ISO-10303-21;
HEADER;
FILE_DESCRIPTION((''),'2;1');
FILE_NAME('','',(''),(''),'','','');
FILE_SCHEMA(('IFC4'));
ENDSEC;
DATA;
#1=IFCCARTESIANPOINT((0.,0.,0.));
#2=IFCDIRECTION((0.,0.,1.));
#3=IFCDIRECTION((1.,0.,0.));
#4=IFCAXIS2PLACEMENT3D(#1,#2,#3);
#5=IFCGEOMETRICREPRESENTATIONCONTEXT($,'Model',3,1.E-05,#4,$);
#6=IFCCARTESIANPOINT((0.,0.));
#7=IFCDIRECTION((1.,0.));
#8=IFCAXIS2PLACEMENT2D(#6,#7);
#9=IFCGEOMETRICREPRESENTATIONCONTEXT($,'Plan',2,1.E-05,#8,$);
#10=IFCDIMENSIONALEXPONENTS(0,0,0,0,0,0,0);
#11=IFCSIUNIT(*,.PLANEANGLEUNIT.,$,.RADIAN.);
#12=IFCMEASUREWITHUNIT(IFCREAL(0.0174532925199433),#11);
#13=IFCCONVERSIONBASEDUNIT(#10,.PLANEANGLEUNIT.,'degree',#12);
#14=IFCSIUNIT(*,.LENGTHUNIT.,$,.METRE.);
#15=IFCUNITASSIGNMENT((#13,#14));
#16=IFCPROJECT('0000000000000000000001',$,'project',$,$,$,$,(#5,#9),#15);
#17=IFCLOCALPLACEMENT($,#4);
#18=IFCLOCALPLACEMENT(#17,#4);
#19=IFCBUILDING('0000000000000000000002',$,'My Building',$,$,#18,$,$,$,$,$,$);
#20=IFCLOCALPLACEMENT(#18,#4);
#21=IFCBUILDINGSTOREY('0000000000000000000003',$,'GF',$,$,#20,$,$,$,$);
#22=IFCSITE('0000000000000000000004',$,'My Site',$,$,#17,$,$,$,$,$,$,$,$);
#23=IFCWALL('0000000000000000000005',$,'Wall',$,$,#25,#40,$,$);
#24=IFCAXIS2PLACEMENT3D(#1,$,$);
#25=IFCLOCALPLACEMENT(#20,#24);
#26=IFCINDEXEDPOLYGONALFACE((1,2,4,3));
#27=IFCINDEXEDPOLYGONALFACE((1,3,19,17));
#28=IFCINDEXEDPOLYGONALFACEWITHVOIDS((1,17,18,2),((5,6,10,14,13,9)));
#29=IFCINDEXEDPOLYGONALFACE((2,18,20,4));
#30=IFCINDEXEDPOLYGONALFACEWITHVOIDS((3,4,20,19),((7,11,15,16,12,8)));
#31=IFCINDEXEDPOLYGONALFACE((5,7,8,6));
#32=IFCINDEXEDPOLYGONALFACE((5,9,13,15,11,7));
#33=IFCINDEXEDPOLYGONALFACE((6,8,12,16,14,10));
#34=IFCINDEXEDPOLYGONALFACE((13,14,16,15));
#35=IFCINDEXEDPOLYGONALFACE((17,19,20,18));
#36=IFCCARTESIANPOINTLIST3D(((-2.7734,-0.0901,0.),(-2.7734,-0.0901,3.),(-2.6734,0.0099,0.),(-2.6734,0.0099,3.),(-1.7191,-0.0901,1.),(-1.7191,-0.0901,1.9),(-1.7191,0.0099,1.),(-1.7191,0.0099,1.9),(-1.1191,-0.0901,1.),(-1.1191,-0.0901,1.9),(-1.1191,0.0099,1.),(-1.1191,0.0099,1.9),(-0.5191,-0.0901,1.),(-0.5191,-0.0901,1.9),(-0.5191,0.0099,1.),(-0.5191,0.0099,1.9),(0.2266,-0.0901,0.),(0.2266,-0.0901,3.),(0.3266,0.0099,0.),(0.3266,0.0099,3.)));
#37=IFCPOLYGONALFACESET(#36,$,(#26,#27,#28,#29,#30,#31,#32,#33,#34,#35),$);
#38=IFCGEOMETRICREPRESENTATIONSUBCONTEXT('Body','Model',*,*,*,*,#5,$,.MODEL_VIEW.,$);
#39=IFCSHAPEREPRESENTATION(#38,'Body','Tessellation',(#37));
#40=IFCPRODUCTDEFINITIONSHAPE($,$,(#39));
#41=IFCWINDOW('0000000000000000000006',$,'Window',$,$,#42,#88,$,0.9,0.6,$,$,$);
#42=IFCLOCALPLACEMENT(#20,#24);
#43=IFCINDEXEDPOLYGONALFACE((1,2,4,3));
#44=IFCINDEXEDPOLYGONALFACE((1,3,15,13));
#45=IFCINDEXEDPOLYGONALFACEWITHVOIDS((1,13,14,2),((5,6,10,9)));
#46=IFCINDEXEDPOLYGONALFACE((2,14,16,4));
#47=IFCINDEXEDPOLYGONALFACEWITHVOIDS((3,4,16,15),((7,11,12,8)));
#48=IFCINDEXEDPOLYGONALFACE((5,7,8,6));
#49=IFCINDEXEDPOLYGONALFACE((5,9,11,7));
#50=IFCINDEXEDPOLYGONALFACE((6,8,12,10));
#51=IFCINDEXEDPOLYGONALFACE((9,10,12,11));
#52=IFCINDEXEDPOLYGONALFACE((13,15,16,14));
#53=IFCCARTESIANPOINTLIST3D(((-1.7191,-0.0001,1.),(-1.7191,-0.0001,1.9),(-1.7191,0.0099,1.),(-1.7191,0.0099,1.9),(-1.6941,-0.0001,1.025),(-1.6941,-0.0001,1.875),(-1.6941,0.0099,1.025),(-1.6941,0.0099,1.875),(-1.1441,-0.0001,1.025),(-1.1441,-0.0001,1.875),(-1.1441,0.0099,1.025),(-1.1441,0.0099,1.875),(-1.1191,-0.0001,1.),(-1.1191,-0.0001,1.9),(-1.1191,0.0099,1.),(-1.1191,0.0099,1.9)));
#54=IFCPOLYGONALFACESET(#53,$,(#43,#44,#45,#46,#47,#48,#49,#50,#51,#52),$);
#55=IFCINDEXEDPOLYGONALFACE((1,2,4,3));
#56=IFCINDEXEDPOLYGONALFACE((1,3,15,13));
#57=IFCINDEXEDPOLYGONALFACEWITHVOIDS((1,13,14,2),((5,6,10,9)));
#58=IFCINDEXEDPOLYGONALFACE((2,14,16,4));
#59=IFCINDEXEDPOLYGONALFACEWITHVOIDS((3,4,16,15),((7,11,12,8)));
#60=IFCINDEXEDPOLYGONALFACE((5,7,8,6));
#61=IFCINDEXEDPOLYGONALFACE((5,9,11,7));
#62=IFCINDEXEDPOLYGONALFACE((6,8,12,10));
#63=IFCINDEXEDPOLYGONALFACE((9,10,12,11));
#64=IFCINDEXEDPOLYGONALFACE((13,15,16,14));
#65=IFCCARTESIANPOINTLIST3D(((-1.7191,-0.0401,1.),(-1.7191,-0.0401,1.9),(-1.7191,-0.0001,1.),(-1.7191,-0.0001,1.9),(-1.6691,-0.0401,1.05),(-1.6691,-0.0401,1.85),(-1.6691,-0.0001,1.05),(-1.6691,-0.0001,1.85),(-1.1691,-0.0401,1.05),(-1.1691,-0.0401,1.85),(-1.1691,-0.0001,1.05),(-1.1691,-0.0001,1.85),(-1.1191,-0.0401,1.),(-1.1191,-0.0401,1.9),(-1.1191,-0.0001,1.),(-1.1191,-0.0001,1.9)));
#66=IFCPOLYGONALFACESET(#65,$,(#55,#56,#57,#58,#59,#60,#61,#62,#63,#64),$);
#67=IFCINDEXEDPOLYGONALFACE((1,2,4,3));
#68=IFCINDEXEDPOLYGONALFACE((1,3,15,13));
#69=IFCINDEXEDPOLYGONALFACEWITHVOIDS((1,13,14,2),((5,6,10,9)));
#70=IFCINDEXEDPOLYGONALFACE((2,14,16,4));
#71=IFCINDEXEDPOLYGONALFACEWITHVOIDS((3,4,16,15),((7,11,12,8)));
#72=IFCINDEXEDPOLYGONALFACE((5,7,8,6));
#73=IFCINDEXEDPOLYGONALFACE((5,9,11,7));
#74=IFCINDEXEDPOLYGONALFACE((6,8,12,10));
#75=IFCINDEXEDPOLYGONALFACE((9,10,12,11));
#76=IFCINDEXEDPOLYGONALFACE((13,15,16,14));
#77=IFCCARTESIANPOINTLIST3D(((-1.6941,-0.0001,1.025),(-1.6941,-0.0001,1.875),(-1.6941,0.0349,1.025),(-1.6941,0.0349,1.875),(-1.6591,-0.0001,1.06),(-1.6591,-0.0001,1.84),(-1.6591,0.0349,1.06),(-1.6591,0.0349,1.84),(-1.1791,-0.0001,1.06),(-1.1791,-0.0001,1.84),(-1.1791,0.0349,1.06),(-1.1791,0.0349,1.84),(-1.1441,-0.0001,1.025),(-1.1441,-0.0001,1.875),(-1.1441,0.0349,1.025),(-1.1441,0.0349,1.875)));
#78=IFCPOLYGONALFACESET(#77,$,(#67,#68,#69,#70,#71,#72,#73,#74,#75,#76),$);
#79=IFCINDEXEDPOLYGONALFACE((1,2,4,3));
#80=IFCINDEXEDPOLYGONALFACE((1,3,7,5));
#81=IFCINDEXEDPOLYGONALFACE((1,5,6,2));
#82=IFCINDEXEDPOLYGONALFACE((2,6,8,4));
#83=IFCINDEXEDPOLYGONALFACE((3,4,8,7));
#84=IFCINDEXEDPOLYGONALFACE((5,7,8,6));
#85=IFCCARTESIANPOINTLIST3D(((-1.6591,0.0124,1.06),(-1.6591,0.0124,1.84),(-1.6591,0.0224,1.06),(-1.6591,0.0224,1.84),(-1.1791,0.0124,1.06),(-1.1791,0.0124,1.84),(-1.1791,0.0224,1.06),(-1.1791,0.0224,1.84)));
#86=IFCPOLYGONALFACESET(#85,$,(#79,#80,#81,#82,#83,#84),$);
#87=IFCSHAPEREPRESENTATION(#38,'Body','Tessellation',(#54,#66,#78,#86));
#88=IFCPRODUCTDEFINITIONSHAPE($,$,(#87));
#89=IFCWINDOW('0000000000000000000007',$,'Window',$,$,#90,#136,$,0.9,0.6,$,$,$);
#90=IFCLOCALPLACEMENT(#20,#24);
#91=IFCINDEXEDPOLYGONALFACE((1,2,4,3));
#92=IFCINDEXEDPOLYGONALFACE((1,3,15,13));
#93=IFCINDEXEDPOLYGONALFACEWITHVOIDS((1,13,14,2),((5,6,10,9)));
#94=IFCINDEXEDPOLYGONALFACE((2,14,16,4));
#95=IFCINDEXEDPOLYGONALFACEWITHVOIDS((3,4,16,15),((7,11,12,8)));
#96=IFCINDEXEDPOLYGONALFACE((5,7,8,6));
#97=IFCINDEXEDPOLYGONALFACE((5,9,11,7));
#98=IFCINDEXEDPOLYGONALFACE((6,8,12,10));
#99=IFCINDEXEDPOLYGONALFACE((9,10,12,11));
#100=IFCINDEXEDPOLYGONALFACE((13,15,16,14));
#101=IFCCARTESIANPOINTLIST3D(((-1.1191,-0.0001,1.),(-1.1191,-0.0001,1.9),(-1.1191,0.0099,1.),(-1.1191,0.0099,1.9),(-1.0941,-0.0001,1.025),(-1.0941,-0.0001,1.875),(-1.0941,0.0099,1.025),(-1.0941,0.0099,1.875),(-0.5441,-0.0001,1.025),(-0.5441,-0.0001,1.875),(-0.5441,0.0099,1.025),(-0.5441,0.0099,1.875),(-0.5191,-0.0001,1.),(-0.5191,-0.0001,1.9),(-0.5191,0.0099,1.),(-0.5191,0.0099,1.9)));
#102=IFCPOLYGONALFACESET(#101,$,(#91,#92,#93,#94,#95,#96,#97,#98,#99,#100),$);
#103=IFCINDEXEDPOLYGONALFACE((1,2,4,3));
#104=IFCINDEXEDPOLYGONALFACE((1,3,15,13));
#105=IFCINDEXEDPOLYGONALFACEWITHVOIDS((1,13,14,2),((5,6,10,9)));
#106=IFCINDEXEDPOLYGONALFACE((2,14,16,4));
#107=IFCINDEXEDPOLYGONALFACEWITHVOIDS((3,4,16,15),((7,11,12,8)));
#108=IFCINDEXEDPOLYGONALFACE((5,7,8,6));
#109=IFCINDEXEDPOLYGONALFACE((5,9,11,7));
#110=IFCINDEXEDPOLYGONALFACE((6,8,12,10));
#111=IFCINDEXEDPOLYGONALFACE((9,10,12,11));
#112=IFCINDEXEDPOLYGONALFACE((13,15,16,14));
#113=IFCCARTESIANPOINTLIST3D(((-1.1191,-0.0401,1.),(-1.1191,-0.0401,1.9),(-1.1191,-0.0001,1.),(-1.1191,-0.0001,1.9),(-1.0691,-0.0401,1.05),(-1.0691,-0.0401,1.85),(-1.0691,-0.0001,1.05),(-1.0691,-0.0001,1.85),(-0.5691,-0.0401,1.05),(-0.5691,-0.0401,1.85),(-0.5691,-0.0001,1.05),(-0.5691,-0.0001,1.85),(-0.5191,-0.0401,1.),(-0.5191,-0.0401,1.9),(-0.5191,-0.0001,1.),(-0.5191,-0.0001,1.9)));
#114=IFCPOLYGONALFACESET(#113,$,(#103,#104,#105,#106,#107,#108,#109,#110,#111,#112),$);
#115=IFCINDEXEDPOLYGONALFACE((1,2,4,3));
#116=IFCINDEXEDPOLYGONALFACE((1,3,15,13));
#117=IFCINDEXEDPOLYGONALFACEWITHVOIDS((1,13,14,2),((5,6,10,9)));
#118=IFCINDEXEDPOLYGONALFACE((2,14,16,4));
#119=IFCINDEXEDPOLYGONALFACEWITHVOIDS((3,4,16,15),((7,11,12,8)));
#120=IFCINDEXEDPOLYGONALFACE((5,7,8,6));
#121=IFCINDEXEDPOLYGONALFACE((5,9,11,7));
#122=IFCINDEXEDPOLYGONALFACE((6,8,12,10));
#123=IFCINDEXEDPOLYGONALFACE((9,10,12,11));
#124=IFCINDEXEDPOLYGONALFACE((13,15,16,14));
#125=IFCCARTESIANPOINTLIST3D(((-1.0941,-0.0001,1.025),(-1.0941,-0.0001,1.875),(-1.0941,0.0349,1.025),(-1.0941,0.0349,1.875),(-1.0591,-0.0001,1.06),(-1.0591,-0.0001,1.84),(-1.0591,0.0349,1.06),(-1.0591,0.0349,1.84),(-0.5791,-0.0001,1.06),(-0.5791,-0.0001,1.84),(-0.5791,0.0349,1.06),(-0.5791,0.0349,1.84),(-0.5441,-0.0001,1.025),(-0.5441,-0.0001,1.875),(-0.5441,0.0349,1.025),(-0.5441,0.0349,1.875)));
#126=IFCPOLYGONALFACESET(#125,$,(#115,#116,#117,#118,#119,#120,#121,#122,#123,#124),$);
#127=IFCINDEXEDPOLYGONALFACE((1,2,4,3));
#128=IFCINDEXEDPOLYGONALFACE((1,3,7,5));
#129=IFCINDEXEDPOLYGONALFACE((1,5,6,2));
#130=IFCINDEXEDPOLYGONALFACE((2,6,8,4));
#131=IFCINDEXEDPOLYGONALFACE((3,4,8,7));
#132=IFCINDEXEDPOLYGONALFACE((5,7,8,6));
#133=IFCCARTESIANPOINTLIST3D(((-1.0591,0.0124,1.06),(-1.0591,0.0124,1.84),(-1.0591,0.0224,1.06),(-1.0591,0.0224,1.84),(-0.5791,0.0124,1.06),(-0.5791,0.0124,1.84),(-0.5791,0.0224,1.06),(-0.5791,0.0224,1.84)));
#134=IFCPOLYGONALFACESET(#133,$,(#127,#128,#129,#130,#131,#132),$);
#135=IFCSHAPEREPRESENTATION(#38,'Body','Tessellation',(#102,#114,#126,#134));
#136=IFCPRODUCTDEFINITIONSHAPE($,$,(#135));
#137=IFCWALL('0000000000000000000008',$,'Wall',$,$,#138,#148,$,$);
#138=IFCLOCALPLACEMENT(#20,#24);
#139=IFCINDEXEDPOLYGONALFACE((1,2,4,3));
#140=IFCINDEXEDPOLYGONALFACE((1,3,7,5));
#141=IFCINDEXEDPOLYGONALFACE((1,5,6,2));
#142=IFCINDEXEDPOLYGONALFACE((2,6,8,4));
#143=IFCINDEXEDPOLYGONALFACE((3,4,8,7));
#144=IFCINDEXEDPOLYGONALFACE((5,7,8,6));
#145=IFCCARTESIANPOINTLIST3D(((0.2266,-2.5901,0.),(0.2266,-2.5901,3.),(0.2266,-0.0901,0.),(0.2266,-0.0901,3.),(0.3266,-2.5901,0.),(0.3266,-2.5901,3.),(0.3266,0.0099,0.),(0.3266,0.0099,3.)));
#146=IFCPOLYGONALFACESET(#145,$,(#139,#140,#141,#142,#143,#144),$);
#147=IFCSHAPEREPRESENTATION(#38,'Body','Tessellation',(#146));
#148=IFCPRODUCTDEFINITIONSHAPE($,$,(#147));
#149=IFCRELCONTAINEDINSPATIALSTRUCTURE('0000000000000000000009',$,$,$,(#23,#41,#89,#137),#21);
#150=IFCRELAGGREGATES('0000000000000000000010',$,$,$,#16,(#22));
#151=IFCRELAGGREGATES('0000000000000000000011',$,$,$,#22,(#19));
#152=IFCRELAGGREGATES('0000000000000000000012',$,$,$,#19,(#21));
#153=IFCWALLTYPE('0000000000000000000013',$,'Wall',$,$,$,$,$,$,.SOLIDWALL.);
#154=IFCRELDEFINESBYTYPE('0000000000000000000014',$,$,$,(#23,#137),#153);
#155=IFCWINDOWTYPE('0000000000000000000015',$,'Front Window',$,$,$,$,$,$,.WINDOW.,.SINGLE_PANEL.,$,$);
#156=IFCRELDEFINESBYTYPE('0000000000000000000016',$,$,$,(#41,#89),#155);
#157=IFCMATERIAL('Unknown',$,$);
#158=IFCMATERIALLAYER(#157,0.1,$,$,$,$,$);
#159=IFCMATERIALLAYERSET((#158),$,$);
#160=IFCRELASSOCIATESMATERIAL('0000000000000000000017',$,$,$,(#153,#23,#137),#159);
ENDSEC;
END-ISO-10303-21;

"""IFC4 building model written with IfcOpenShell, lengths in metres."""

from ifc_helpers import new_model, entity, si_unit, converted_unit, frame, origin_with_axes, origin_2d_with_axis, place, context, subcontext, project, spatial, line, indexed_curve, outline, extrude, shape, source, transform, mapped, material, layer, layer_set, layer_usage, type_object, type_shapes, element, fill, save


model = new_model("IFC4")

# Units and contexts
model_context = context("Model", 3, precision=1e-05, world=origin_with_axes())
plan_context = context("Plan", 2, precision=1e-05, world=origin_2d_with_axis())
body_context_1 = subcontext(model_context, "Body", "Model", "MODEL_VIEW")
body_context_2 = subcontext(plan_context, "Body", "Plan", "PLAN_VIEW")
ifc_project = project(units=[converted_unit("PLANEANGLEUNIT", "degree", entity("IfcReal", 0.0174532925199433), si_unit("PLANEANGLEUNIT", "RADIAN"), dimensions=[0, 0, 0, 0, 0, 0, 0]), si_unit("LENGTHUNIT", "METRE")], contexts=[model_context, plan_context])

# Site, building, storey
site_placement = place(None, origin_with_axes())
site = spatial("IfcSite", under=ifc_project, at=site_placement, Name="My Site")
building_placement = place(site_placement, origin_with_axes())
building = spatial("IfcBuilding", under=site, at=building_placement, Name="My Building")
storey_placement = place(building_placement, origin_with_axes())
storey = spatial("IfcBuildingStorey", under=building, at=storey_placement, Name="GF")

# Shared definitions
ifc_material_1 = material(Name="Unknown")

# Shared definitions
ifc_layer_1 = layer(ifc_material_1, 0.1)
ifc_layer_set_1 = layer_set([ifc_layer_1])
wall_type = type_object("IfcWallType", Name="Wall", PredefinedType="SOLIDWALL", material=ifc_layer_set_1)
shared_shape_1 = source(origin_with_axes(), body_context_1, "Body", "SweptSolid", [
    extrude(outline(indexed_curve([(0.0, 0.0), (0.6, 0.0), (0.6, 0.9), (0.0, 0.9)], segments=[line(1, 2, 3, 4, 1)])), frame((0.0, -0.6, 0.0), z_axis=(0.0, -1.0, 0.0), x_axis=(1.0, 0.0, 0.0)), (0.0, 0.0, -1.0), 1.2),
])
window_type = type_object("IfcWindowType", Name="Front Window", PartitioningType="SINGLE_PANEL", PredefinedType="WINDOW")
shared_shape_2 = source(origin_with_axes(), body_context_1, "Body", "SweptSolid", [
    extrude(outline(indexed_curve([(0.0, 0.0), (0.6, 0.0), (0.6, 0.9), (0.0, 0.9)], segments=[line(1, 2, 3, 4, 1)]), holes=[indexed_curve([(0.025, 0.025), (0.575, 0.025), (0.575, 0.875), (0.025, 0.875)], segments=[line(1, 2, 3, 4, 1)])]), frame((0.0, 0.09, 0.0), z_axis=(0.0, -1.0, 0.0), x_axis=(1.0, 0.0, 0.0)), (0.0, 0.0, -1.0), 0.01),
    extrude(outline(indexed_curve([(0.0, 0.0), (0.6, 0.0), (0.6, 0.9), (0.0, 0.9)], segments=[line(1, 2, 3, 4, 1)]), holes=[indexed_curve([(0.05, 0.05), (0.55, 0.05), (0.55, 0.85), (0.05, 0.85)], segments=[line(1, 2, 3, 4, 1)])]), frame((0.0, 0.05, 0.0), z_axis=(0.0, -1.0, 0.0), x_axis=(1.0, 0.0, 0.0)), (0.0, 0.0, -1.0), 0.04),
    extrude(outline(indexed_curve([(0.0, 0.0), (0.55, 0.0), (0.55, 0.85), (0.0, 0.85)], segments=[line(1, 2, 3, 4, 1)]), holes=[indexed_curve([(0.035, 0.035), (0.515, 0.035), (0.515, 0.815), (0.035, 0.815)], segments=[line(1, 2, 3, 4, 1)])]), frame((0.025, 0.09, 0.025), z_axis=(0.0, -1.0, 0.0), x_axis=(1.0, 0.0, 0.0)), (0.0, 0.0, -1.0), 0.035),
    extrude(outline(indexed_curve([(0.035, 0.035), (0.515, 0.035), (0.515, 0.815), (0.035, 0.815)], segments=[line(1, 2, 3, 4, 1)])), frame((0.025, 0.1025, 0.025), z_axis=(0.0, -1.0, 0.0), x_axis=(1.0, 0.0, 0.0)), (0.0, 0.0, -1.0), 0.01),
])
shared_shape_3 = source(origin_with_axes(), body_context_2, "Body", "Curve2D", [
    entity("IfcIndexedPolyCurve", entity("IfcCartesianPointList2D", [[0.05, 0.05], [0.55, 0.05]])),
    entity("IfcIndexedPolyCurve", entity("IfcCartesianPointList2D", [[0.0, 0.1], [0.025, 0.1], [0.025, 0.09], [0.05, 0.09], [0.05, 0.05], [0.0, 0.05]]), [entity("IfcLineIndex", [1, 2, 3, 4, 5, 6, 1])]),
    entity("IfcIndexedPolyCurve", entity("IfcCartesianPointList2D", [[0.6, 0.1], [0.575, 0.1], [0.575, 0.09], [0.55, 0.09], [0.55, 0.05], [0.6, 0.05]]), [entity("IfcLineIndex", [1, 2, 3, 4, 5, 6, 1])]),
    entity("IfcIndexedPolyCurve", entity("IfcCartesianPointList2D", [[0.025, 0.09], [0.06, 0.09], [0.06, 0.125], [0.025, 0.125]]), [entity("IfcLineIndex", [1, 2, 3, 4, 1])]),
    entity("IfcIndexedPolyCurve", entity("IfcCartesianPointList2D", [[0.575, 0.09], [0.54, 0.09], [0.54, 0.125], [0.575, 0.125]]), [entity("IfcLineIndex", [1, 2, 3, 4, 1])]),
    entity("IfcIndexedPolyCurve", entity("IfcCartesianPointList2D", [[0.06, 0.09], [0.54, 0.09]])),
    entity("IfcIndexedPolyCurve", entity("IfcCartesianPointList2D", [[0.06, 0.125], [0.54, 0.125]])),
    entity("IfcIndexedPolyCurve", entity("IfcCartesianPointList2D", [[0.06, 0.1075], [0.54, 0.1075]])),
])
type_shapes(window_type, [shared_shape_2, shared_shape_3])

# Wall, openings, windows
ifc_layer_usage_1 = layer_usage(ifc_layer_set_1, "AXIS2", "POSITIVE", 0.0)
wall_1_placement = place(storey_placement, frame((-2.7734, -0.0901, 0.0), z_axis=(0.0, 0.0, 1.0), x_axis=(1.0, 0.0, 0.0)))
wall_1 = element("IfcWall", 1, at=wall_1_placement, inside=storey, type_object=wall_type, material=ifc_layer_usage_1, Name="Wall", context=body_context_1, shape_type="SweptSolid", body=[
    extrude(outline(indexed_curve([(0.0, 0.0), (0.1, 0.1), (3.1, 0.1), (3.0, 0.0)], segments=[line(1, 2, 3, 4, 1)])), origin_with_axes(), (0.0, 0.0, 1.0), 3.0),
])
opening_1_placement = place(wall_1_placement, frame((1.0543, 0.0, 1.0), z_axis=(0.0, 0.0, 1.0), x_axis=(1.0, 0.0, 0.0)))
opening_1 = element("IfcOpeningElement", 2, at=opening_1_placement, cuts=wall_1, PredefinedType="OPENING", context=body_context_1, shape_type="MappedRepresentation", body=[
    mapped(shared_shape_1, transform((0.0, 0.0, 0.0), x_axis=(1.0, 0.0, 0.0), y_axis=(0.0, 1.0, 0.0), z_axis=(0.0, 0.0, 1.0), scale=1.0)),
])
opening_2_placement = place(wall_1_placement, frame((1.6543, 0.0, 1.0), z_axis=(0.0, 0.0, 1.0), x_axis=(1.0, 0.0, 0.0)))
opening_2 = element("IfcOpeningElement", 3, at=opening_2_placement, cuts=wall_1, PredefinedType="OPENING", context=body_context_1, shape_type="MappedRepresentation", body=[
    mapped(shared_shape_1, transform((0.0, 0.0, 0.0), x_axis=(1.0, 0.0, 0.0), y_axis=(0.0, 1.0, 0.0), z_axis=(0.0, 0.0, 1.0), scale=1.0)),
])
window_1_placement = place(opening_1_placement, origin_with_axes())
window_1 = element("IfcWindow", 4, at=window_1_placement, inside=storey, type_object=window_type, Name="Window", OverallHeight=0.9, OverallWidth=0.6, shapes=[
    shape(body_context_1, "Body", "MappedRepresentation", [mapped(shared_shape_2, transform((0.0, 0.0, 0.0), x_axis=(1.0, 0.0, 0.0), y_axis=(0.0, 1.0, 0.0), z_axis=(0.0, 0.0, 1.0), scale=1.0))]),
    shape(body_context_2, "Body", "MappedRepresentation", [mapped(shared_shape_3, transform((0.0, 0.0, 0.0), x_axis=(1.0, 0.0, 0.0), y_axis=(0.0, 1.0, 0.0), z_axis=(0.0, 0.0, 1.0), scale=1.0))]),
])
fill(opening_1, window_1)
window_2_placement = place(opening_2_placement, origin_with_axes())
window_2 = element("IfcWindow", 5, at=window_2_placement, inside=storey, type_object=window_type, Name="Window", OverallHeight=0.9, OverallWidth=0.6, shapes=[
    shape(body_context_1, "Body", "MappedRepresentation", [mapped(shared_shape_2, transform((0.0, 0.0, 0.0), x_axis=(1.0, 0.0, 0.0), y_axis=(0.0, 1.0, 0.0), z_axis=(0.0, 0.0, 1.0), scale=1.0))]),
    shape(body_context_2, "Body", "MappedRepresentation", [mapped(shared_shape_3, transform((0.0, 0.0, 0.0), x_axis=(1.0, 0.0, 0.0), y_axis=(0.0, 1.0, 0.0), z_axis=(0.0, 0.0, 1.0), scale=1.0))]),
])
fill(opening_2, window_2)

# Wall
ifc_layer_usage_2 = layer_usage(ifc_layer_set_1, "AXIS2", "POSITIVE", 0.0)
wall_2_placement = place(storey_placement, frame((0.2266, -0.0901, 0.0), z_axis=(0.0, 0.0, 1.0), x_axis=(0.0, -1.0, 0.0)))
element("IfcWall", 6, at=wall_2_placement, inside=storey, type_object=wall_type, material=ifc_layer_usage_2, Name="Wall", context=body_context_1, shape_type="SweptSolid", body=[
    extrude(outline(indexed_curve([(0.0, 0.0), (-0.1, 0.1), (2.5, 0.1), (2.5, 0.0)], segments=[line(1, 2, 3, 4, 1)])), origin_with_axes(), (0.0, 0.0, 1.0), 3.0),
])

save(model, "model.ifc")
